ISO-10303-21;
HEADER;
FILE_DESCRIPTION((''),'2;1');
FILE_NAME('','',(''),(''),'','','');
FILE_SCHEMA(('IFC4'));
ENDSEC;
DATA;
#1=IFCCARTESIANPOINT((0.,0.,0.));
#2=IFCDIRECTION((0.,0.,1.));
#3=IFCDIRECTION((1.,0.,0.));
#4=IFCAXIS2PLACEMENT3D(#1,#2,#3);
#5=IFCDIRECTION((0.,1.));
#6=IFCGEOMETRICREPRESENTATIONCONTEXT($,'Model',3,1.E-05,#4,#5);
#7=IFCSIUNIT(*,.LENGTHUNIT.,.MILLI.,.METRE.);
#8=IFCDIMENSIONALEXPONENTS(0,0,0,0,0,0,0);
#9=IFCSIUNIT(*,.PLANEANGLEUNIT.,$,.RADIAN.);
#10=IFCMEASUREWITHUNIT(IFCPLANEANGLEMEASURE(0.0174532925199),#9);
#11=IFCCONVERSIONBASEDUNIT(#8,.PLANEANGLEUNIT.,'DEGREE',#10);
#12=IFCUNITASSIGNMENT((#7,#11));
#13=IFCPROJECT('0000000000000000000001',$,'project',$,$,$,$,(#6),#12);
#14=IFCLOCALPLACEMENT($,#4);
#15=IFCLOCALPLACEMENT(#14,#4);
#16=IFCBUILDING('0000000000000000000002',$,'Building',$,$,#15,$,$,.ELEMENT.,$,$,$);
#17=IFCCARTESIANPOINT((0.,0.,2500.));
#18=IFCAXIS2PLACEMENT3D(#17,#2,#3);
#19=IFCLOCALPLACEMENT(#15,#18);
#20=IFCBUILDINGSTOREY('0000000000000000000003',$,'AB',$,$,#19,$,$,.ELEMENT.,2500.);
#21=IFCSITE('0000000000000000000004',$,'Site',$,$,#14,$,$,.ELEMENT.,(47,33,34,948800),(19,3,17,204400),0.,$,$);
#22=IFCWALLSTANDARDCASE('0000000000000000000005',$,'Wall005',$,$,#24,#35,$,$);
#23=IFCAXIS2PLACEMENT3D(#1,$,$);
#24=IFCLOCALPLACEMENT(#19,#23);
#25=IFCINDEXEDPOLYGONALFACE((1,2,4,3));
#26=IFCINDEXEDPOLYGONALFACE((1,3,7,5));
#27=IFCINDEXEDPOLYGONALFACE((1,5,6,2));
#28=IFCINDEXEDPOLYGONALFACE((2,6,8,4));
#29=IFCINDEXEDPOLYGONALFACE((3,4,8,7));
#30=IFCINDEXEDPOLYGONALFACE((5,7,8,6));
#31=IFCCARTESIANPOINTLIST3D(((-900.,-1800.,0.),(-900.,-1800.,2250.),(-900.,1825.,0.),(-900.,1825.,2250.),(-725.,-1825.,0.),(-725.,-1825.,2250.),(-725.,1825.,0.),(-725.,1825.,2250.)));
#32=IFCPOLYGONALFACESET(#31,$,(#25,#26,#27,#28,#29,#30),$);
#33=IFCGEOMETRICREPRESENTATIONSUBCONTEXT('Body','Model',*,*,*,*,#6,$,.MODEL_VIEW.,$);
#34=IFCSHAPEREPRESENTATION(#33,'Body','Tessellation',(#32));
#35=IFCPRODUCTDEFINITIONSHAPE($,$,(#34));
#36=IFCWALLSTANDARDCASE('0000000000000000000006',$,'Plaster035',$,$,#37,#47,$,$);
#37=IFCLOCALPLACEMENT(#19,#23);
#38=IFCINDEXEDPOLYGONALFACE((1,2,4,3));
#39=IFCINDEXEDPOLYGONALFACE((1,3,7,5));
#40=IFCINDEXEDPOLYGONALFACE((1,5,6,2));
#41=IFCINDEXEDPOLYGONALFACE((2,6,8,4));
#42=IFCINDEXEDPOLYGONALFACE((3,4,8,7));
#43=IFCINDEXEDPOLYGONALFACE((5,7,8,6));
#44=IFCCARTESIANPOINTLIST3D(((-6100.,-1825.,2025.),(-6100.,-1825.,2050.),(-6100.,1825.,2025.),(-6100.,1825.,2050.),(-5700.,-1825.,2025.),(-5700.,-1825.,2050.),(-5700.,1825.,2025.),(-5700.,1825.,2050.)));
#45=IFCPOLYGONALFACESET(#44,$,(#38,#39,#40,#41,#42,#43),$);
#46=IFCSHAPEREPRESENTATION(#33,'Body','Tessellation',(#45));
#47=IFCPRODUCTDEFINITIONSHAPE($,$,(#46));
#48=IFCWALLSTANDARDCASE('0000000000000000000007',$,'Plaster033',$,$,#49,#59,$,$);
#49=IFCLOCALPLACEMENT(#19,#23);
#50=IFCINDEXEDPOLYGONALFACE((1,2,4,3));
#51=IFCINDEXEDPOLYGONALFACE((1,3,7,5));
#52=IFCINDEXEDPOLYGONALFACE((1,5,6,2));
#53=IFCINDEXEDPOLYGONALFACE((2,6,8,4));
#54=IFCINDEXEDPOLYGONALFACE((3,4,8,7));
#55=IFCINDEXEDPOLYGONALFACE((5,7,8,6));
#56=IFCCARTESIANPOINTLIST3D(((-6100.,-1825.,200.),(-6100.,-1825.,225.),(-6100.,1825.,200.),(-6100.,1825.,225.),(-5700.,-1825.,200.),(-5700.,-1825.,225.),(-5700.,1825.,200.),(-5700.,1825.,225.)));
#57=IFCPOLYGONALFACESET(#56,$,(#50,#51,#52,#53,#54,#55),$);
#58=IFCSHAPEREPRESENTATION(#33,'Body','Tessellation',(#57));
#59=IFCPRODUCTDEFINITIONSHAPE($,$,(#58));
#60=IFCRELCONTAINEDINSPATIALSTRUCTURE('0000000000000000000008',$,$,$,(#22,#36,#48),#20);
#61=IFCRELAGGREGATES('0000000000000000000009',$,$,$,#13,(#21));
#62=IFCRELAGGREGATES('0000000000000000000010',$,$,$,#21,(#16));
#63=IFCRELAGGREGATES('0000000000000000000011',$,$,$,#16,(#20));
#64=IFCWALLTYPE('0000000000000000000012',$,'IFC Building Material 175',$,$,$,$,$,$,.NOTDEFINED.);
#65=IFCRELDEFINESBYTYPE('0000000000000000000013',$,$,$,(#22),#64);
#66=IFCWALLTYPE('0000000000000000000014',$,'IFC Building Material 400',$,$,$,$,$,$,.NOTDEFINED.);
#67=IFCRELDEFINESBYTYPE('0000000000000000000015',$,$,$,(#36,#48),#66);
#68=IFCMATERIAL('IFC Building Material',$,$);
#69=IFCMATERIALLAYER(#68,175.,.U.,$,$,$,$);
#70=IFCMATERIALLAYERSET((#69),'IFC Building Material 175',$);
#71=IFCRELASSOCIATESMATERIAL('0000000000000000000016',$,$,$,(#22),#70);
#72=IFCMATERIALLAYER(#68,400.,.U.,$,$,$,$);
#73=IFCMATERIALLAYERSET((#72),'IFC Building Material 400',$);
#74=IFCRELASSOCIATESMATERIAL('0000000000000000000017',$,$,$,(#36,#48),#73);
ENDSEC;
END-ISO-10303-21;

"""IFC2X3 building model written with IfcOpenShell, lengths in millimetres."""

from ifc_helpers import new_model, entity, si_unit, converted_unit, direction, frame, origin_with_axes, place, context, subcontext, project, spatial, polyline, outline, extrude, material, layer, layer_set, layer_usage, type_object, element, save


model = new_model("IFC2X3")

# Units and contexts
model_context = context("Model", 3, precision=1e-05, world=origin_with_axes(), true_north=direction((0.0, 1.0)))
body_context = subcontext(model_context, "Body", "Model", "MODEL_VIEW")
ifc_project = project(units=[si_unit("LENGTHUNIT", "METRE", prefix="MILLI"), converted_unit("PLANEANGLEUNIT", "DEGREE", entity("IfcPlaneAngleMeasure", 0.0174532925199), si_unit("PLANEANGLEUNIT", "RADIAN"), dimensions=[0, 0, 0, 0, 0, 0, 0])], contexts=[model_context])

# Site, building, storey
site_placement = place(None, origin_with_axes())
site = spatial("IfcSite", under=ifc_project, at=site_placement, Name="Site", CompositionType="ELEMENT", RefLatitude=(47, 33, 34, 948800), RefLongitude=(19, 3, 17, 204400), RefElevation=0.0)
building_placement = place(site_placement, origin_with_axes())
building = spatial("IfcBuilding", under=site, at=building_placement, Name="Building", CompositionType="ELEMENT")
storey_placement = place(building_placement, frame((0.0, 0.0, 2500.0), z_axis=(0.0, 0.0, 1.0), x_axis=(1.0, 0.0, 0.0)))
storey = spatial("IfcBuildingStorey", under=building, at=storey_placement, Name="AB", CompositionType="ELEMENT", Elevation=2500.0)

# Shared definitions
ifc_material = material(Name="IFC Building Material")

# Walls
ifc_layer_1 = layer(ifc_material, 175.0, ventilated="UNKNOWN")
ifc_layer_set_1 = layer_set([ifc_layer_1], Name="IFC Building Material 175")
ifc_layer_usage_1 = layer_usage(ifc_layer_set_1, "AXIS2", "POSITIVE", 0.0)
wall_type_1 = type_object("IfcWallType", Name="IFC Building Material 175", PredefinedType="NOTDEFINED")
wall_1_placement = place(storey_placement, frame((-900.0, 1825.0, 0.0), z_axis=(0.0, 0.0, 1.0), x_axis=(0.0, -1.0, 0.0)))
element("IfcWallStandardCase", 1, at=wall_1_placement, inside=storey, type_object=wall_type_1, material=ifc_layer_usage_1, Name="Wall005", context=body_context, shape_type="SweptSolid", body=[
    extrude(outline(polyline([(0.0, 0.0), (3625.0, 0.0), (3650.0, 175.0), (0.0, 175.0), (0.0, 0.0)])), origin_with_axes(), (0.0, 0.0, 1.0), 2250.0),
])
ifc_layer_2 = layer(ifc_material, 400.0, ventilated="UNKNOWN")
ifc_layer_set_2 = layer_set([ifc_layer_2], Name="IFC Building Material 400")
ifc_layer_usage_2 = layer_usage(ifc_layer_set_2, "AXIS2", "POSITIVE", 0.0)
wall_type_2 = type_object("IfcWallType", Name="IFC Building Material 400", PredefinedType="NOTDEFINED")
wall_2_placement = place(storey_placement, frame((-5700.0, -1825.0, 2025.0), z_axis=(0.0, 0.0, 1.0), x_axis=(0.0, 1.0, 0.0)))
element("IfcWallStandardCase", 2, at=wall_2_placement, inside=storey, type_object=wall_type_2, material=ifc_layer_usage_2, Name="Plaster035", context=body_context, shape_type="SweptSolid", body=[
    extrude(outline(polyline([(0.0, 0.0), (3650.0, 0.0), (3650.0, 400.0), (0.0, 400.0), (0.0, 0.0)])), origin_with_axes(), (0.0, 0.0, 1.0), 25.0),
])
ifc_layer_usage_3 = layer_usage(ifc_layer_set_2, "AXIS2", "NEGATIVE", 0.0)
wall_3_placement = place(storey_placement, frame((-6100.0, -1825.0, 200.0), z_axis=(0.0, 0.0, 1.0), x_axis=(0.0, 1.0, 0.0)))
element("IfcWallStandardCase", 3, at=wall_3_placement, inside=storey, type_object=wall_type_2, material=ifc_layer_usage_3, Name="Plaster033", context=body_context, shape_type="SweptSolid", body=[
    extrude(outline(polyline([(0.0, -400.0), (3650.0, -400.0), (3650.0, 0.0), (0.0, 0.0), (0.0, -400.0)])), origin_with_axes(), (0.0, 0.0, 1.0), 25.0),
])

save(model, "model.ifc")
